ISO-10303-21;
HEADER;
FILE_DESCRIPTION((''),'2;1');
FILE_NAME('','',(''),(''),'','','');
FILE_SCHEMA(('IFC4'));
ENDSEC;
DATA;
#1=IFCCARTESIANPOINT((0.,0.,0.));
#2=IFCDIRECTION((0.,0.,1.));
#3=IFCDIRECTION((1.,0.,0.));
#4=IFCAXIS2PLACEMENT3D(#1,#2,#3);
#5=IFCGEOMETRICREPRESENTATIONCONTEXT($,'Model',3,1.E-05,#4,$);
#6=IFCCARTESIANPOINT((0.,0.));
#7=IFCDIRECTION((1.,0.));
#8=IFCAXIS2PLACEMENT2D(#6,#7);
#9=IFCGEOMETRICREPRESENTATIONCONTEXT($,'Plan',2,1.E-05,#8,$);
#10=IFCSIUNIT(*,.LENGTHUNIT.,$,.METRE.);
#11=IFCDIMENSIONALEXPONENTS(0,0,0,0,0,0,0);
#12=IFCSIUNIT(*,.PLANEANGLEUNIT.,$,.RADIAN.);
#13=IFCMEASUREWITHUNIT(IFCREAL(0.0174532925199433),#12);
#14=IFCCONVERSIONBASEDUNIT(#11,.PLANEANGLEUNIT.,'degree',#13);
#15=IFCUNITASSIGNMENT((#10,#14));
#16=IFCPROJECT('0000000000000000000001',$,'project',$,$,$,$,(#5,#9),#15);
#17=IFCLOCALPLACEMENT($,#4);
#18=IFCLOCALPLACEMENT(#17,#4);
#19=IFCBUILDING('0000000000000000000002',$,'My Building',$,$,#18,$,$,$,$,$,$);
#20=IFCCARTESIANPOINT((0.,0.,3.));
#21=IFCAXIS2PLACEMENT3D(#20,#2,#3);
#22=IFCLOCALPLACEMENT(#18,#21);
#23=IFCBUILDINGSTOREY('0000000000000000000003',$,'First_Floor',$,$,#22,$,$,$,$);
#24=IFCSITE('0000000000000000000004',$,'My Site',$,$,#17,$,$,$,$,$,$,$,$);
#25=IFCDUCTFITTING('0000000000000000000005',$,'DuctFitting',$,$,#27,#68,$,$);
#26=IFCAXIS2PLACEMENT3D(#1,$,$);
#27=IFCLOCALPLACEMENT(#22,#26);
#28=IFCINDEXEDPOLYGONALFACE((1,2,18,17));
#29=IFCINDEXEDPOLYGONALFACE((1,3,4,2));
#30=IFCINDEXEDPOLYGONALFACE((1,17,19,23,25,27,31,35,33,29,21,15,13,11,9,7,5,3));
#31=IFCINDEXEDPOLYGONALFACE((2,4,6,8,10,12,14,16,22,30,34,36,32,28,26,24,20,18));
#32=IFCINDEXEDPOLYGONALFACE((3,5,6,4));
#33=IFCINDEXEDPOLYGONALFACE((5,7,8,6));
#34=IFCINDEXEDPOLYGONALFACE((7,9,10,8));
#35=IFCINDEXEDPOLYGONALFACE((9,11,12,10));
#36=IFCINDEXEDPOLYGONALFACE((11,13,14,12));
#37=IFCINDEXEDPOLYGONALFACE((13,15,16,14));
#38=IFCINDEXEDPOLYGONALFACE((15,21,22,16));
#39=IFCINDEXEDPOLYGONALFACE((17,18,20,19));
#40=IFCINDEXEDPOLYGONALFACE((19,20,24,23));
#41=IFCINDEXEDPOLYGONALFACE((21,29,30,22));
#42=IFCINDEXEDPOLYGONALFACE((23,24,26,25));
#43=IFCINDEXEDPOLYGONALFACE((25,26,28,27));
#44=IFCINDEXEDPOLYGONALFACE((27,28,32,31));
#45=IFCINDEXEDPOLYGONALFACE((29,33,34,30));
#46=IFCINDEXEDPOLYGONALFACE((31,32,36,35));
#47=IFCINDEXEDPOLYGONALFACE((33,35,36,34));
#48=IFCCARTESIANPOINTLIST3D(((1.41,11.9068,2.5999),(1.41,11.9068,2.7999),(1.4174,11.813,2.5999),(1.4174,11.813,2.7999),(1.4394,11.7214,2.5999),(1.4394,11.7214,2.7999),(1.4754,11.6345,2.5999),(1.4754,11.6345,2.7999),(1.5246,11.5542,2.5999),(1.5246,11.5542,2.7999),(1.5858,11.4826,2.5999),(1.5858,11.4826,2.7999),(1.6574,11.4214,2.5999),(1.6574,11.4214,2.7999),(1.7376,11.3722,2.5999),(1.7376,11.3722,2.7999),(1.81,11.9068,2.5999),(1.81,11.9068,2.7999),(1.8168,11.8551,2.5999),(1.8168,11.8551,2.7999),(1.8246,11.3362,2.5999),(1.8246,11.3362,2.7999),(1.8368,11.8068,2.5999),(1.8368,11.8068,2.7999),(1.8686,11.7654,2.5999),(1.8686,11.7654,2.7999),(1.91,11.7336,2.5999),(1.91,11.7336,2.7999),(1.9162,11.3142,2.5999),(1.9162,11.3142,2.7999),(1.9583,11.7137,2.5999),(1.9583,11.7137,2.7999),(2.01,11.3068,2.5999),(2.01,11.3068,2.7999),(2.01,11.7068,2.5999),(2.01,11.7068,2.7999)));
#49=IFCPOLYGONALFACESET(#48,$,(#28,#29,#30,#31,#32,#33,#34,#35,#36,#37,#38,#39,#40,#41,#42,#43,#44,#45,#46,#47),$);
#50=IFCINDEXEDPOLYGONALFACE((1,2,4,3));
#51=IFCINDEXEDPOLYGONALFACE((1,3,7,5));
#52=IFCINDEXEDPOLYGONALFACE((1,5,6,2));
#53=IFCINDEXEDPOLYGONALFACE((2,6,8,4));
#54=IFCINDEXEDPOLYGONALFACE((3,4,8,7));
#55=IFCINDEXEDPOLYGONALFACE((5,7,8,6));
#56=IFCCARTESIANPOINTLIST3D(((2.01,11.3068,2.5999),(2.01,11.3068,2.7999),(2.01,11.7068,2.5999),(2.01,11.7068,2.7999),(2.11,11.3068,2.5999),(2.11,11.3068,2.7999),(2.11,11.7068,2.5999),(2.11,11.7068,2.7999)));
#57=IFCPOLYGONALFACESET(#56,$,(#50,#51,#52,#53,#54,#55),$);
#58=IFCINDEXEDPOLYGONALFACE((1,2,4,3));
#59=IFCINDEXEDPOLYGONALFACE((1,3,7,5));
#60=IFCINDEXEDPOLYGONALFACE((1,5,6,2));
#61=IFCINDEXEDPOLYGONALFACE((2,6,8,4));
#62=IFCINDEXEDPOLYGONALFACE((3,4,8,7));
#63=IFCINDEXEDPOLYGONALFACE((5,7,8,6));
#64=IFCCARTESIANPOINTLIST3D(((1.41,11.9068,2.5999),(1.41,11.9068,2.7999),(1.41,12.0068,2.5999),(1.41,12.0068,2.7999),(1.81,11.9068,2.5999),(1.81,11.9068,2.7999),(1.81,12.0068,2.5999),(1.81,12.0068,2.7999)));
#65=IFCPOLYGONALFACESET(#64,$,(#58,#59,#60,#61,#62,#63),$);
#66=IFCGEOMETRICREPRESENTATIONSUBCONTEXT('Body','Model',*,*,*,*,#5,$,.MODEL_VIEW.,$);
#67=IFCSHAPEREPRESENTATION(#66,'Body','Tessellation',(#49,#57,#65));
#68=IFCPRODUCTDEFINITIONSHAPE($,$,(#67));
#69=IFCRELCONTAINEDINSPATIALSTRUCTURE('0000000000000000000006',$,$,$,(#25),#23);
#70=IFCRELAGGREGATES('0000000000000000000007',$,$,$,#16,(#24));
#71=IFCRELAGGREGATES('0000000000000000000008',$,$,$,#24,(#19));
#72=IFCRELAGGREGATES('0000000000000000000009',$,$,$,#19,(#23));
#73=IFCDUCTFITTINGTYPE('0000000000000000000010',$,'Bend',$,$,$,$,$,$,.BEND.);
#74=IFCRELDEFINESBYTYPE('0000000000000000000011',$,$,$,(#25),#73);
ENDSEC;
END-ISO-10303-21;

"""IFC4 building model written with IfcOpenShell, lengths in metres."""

from ifc_helpers import new_model, entity, si_unit, converted_unit, frame, origin_with_axes, origin_2d_with_axis, place, context, subcontext, project, spatial, line, arc, indexed_curve, rectangle, outline, extrude, source, transform, mapped, type_object, type_shapes, element, save


model = new_model("IFC4")

# Units and contexts
model_context = context("Model", 3, precision=1e-05, world=origin_with_axes())
plan_context = context("Plan", 2, precision=1e-05, world=origin_2d_with_axis())
body_context_1 = subcontext(model_context, "Body", "Model", "MODEL_VIEW")
ifc_project = project(units=[si_unit("LENGTHUNIT", "METRE"), converted_unit("PLANEANGLEUNIT", "degree", entity("IfcReal", 0.0174532925199433), si_unit("PLANEANGLEUNIT", "RADIAN"), dimensions=[0, 0, 0, 0, 0, 0, 0])], contexts=[model_context, plan_context])

# Site, building, storey
site_placement = place(None, origin_with_axes())
site = spatial("IfcSite", under=ifc_project, at=site_placement, Name="My Site")
building_placement = place(site_placement, origin_with_axes())
building = spatial("IfcBuilding", under=site, at=building_placement, Name="My Building")
storey_placement = place(building_placement, frame((0.0, 0.0, 3.0), z_axis=(0.0, 0.0, 1.0), x_axis=(1.0, 0.0, 0.0)))
storey = spatial("IfcBuildingStorey", under=building, at=storey_placement, Name="First_Floor")

# Duct fitting
duct_fitting_type = type_object("IfcDuctFittingType", Name="Bend", PredefinedType="BEND")
shared_shape_1 = source(origin_with_axes(), body_context_1, "Body", "SweptSolid", [
    extrude(outline(indexed_curve([(-0.2, 0.0), (-0.2586, 0.1414), (-0.4, 0.2), (-0.4, 0.6), (0.0243, 0.4243), (0.2, 0.0)], segments=[arc(1, 2, 3), line(3, 4), arc(4, 5, 6), line(6, 1)])), frame((0.0, -0.1, 0.1), z_axis=(0.0, -1.0, 0.0), x_axis=(1.0, 0.0, 0.0)), (0.0, 0.0, -1.0), 0.2),
    extrude(rectangle(XDim=0.4, YDim=0.2), origin_with_axes(), (0.0, 0.0, 1.0), 0.1),
    extrude(rectangle(XDim=0.4, YDim=0.2), frame((-0.4, 0.0, 0.5), z_axis=(-1.0, 0.0, 0.0), x_axis=(0.0, 0.0, -1.0)), (0.0, 0.0, 1.0), 0.1),
])
type_shapes(duct_fitting_type, [shared_shape_1])
duct_fitting_placement = place(storey_placement, frame((2.11, 11.5068, 2.6999), z_axis=(-1.0, 0.0, 0.0), x_axis=(0.0, -1.0, 0.0)))
element("IfcDuctFitting", 1, at=duct_fitting_placement, inside=storey, type_object=duct_fitting_type, Name="DuctFitting", context=body_context_1, shape_type="MappedRepresentation", body=[
    mapped(shared_shape_1, transform((0.0, 0.0, 0.0), x_axis=(1.0, 0.0, 0.0), y_axis=(0.0, 1.0, 0.0), z_axis=(0.0, 0.0, 1.0), scale=1.0)),
])

save(model, "model.ifc")
